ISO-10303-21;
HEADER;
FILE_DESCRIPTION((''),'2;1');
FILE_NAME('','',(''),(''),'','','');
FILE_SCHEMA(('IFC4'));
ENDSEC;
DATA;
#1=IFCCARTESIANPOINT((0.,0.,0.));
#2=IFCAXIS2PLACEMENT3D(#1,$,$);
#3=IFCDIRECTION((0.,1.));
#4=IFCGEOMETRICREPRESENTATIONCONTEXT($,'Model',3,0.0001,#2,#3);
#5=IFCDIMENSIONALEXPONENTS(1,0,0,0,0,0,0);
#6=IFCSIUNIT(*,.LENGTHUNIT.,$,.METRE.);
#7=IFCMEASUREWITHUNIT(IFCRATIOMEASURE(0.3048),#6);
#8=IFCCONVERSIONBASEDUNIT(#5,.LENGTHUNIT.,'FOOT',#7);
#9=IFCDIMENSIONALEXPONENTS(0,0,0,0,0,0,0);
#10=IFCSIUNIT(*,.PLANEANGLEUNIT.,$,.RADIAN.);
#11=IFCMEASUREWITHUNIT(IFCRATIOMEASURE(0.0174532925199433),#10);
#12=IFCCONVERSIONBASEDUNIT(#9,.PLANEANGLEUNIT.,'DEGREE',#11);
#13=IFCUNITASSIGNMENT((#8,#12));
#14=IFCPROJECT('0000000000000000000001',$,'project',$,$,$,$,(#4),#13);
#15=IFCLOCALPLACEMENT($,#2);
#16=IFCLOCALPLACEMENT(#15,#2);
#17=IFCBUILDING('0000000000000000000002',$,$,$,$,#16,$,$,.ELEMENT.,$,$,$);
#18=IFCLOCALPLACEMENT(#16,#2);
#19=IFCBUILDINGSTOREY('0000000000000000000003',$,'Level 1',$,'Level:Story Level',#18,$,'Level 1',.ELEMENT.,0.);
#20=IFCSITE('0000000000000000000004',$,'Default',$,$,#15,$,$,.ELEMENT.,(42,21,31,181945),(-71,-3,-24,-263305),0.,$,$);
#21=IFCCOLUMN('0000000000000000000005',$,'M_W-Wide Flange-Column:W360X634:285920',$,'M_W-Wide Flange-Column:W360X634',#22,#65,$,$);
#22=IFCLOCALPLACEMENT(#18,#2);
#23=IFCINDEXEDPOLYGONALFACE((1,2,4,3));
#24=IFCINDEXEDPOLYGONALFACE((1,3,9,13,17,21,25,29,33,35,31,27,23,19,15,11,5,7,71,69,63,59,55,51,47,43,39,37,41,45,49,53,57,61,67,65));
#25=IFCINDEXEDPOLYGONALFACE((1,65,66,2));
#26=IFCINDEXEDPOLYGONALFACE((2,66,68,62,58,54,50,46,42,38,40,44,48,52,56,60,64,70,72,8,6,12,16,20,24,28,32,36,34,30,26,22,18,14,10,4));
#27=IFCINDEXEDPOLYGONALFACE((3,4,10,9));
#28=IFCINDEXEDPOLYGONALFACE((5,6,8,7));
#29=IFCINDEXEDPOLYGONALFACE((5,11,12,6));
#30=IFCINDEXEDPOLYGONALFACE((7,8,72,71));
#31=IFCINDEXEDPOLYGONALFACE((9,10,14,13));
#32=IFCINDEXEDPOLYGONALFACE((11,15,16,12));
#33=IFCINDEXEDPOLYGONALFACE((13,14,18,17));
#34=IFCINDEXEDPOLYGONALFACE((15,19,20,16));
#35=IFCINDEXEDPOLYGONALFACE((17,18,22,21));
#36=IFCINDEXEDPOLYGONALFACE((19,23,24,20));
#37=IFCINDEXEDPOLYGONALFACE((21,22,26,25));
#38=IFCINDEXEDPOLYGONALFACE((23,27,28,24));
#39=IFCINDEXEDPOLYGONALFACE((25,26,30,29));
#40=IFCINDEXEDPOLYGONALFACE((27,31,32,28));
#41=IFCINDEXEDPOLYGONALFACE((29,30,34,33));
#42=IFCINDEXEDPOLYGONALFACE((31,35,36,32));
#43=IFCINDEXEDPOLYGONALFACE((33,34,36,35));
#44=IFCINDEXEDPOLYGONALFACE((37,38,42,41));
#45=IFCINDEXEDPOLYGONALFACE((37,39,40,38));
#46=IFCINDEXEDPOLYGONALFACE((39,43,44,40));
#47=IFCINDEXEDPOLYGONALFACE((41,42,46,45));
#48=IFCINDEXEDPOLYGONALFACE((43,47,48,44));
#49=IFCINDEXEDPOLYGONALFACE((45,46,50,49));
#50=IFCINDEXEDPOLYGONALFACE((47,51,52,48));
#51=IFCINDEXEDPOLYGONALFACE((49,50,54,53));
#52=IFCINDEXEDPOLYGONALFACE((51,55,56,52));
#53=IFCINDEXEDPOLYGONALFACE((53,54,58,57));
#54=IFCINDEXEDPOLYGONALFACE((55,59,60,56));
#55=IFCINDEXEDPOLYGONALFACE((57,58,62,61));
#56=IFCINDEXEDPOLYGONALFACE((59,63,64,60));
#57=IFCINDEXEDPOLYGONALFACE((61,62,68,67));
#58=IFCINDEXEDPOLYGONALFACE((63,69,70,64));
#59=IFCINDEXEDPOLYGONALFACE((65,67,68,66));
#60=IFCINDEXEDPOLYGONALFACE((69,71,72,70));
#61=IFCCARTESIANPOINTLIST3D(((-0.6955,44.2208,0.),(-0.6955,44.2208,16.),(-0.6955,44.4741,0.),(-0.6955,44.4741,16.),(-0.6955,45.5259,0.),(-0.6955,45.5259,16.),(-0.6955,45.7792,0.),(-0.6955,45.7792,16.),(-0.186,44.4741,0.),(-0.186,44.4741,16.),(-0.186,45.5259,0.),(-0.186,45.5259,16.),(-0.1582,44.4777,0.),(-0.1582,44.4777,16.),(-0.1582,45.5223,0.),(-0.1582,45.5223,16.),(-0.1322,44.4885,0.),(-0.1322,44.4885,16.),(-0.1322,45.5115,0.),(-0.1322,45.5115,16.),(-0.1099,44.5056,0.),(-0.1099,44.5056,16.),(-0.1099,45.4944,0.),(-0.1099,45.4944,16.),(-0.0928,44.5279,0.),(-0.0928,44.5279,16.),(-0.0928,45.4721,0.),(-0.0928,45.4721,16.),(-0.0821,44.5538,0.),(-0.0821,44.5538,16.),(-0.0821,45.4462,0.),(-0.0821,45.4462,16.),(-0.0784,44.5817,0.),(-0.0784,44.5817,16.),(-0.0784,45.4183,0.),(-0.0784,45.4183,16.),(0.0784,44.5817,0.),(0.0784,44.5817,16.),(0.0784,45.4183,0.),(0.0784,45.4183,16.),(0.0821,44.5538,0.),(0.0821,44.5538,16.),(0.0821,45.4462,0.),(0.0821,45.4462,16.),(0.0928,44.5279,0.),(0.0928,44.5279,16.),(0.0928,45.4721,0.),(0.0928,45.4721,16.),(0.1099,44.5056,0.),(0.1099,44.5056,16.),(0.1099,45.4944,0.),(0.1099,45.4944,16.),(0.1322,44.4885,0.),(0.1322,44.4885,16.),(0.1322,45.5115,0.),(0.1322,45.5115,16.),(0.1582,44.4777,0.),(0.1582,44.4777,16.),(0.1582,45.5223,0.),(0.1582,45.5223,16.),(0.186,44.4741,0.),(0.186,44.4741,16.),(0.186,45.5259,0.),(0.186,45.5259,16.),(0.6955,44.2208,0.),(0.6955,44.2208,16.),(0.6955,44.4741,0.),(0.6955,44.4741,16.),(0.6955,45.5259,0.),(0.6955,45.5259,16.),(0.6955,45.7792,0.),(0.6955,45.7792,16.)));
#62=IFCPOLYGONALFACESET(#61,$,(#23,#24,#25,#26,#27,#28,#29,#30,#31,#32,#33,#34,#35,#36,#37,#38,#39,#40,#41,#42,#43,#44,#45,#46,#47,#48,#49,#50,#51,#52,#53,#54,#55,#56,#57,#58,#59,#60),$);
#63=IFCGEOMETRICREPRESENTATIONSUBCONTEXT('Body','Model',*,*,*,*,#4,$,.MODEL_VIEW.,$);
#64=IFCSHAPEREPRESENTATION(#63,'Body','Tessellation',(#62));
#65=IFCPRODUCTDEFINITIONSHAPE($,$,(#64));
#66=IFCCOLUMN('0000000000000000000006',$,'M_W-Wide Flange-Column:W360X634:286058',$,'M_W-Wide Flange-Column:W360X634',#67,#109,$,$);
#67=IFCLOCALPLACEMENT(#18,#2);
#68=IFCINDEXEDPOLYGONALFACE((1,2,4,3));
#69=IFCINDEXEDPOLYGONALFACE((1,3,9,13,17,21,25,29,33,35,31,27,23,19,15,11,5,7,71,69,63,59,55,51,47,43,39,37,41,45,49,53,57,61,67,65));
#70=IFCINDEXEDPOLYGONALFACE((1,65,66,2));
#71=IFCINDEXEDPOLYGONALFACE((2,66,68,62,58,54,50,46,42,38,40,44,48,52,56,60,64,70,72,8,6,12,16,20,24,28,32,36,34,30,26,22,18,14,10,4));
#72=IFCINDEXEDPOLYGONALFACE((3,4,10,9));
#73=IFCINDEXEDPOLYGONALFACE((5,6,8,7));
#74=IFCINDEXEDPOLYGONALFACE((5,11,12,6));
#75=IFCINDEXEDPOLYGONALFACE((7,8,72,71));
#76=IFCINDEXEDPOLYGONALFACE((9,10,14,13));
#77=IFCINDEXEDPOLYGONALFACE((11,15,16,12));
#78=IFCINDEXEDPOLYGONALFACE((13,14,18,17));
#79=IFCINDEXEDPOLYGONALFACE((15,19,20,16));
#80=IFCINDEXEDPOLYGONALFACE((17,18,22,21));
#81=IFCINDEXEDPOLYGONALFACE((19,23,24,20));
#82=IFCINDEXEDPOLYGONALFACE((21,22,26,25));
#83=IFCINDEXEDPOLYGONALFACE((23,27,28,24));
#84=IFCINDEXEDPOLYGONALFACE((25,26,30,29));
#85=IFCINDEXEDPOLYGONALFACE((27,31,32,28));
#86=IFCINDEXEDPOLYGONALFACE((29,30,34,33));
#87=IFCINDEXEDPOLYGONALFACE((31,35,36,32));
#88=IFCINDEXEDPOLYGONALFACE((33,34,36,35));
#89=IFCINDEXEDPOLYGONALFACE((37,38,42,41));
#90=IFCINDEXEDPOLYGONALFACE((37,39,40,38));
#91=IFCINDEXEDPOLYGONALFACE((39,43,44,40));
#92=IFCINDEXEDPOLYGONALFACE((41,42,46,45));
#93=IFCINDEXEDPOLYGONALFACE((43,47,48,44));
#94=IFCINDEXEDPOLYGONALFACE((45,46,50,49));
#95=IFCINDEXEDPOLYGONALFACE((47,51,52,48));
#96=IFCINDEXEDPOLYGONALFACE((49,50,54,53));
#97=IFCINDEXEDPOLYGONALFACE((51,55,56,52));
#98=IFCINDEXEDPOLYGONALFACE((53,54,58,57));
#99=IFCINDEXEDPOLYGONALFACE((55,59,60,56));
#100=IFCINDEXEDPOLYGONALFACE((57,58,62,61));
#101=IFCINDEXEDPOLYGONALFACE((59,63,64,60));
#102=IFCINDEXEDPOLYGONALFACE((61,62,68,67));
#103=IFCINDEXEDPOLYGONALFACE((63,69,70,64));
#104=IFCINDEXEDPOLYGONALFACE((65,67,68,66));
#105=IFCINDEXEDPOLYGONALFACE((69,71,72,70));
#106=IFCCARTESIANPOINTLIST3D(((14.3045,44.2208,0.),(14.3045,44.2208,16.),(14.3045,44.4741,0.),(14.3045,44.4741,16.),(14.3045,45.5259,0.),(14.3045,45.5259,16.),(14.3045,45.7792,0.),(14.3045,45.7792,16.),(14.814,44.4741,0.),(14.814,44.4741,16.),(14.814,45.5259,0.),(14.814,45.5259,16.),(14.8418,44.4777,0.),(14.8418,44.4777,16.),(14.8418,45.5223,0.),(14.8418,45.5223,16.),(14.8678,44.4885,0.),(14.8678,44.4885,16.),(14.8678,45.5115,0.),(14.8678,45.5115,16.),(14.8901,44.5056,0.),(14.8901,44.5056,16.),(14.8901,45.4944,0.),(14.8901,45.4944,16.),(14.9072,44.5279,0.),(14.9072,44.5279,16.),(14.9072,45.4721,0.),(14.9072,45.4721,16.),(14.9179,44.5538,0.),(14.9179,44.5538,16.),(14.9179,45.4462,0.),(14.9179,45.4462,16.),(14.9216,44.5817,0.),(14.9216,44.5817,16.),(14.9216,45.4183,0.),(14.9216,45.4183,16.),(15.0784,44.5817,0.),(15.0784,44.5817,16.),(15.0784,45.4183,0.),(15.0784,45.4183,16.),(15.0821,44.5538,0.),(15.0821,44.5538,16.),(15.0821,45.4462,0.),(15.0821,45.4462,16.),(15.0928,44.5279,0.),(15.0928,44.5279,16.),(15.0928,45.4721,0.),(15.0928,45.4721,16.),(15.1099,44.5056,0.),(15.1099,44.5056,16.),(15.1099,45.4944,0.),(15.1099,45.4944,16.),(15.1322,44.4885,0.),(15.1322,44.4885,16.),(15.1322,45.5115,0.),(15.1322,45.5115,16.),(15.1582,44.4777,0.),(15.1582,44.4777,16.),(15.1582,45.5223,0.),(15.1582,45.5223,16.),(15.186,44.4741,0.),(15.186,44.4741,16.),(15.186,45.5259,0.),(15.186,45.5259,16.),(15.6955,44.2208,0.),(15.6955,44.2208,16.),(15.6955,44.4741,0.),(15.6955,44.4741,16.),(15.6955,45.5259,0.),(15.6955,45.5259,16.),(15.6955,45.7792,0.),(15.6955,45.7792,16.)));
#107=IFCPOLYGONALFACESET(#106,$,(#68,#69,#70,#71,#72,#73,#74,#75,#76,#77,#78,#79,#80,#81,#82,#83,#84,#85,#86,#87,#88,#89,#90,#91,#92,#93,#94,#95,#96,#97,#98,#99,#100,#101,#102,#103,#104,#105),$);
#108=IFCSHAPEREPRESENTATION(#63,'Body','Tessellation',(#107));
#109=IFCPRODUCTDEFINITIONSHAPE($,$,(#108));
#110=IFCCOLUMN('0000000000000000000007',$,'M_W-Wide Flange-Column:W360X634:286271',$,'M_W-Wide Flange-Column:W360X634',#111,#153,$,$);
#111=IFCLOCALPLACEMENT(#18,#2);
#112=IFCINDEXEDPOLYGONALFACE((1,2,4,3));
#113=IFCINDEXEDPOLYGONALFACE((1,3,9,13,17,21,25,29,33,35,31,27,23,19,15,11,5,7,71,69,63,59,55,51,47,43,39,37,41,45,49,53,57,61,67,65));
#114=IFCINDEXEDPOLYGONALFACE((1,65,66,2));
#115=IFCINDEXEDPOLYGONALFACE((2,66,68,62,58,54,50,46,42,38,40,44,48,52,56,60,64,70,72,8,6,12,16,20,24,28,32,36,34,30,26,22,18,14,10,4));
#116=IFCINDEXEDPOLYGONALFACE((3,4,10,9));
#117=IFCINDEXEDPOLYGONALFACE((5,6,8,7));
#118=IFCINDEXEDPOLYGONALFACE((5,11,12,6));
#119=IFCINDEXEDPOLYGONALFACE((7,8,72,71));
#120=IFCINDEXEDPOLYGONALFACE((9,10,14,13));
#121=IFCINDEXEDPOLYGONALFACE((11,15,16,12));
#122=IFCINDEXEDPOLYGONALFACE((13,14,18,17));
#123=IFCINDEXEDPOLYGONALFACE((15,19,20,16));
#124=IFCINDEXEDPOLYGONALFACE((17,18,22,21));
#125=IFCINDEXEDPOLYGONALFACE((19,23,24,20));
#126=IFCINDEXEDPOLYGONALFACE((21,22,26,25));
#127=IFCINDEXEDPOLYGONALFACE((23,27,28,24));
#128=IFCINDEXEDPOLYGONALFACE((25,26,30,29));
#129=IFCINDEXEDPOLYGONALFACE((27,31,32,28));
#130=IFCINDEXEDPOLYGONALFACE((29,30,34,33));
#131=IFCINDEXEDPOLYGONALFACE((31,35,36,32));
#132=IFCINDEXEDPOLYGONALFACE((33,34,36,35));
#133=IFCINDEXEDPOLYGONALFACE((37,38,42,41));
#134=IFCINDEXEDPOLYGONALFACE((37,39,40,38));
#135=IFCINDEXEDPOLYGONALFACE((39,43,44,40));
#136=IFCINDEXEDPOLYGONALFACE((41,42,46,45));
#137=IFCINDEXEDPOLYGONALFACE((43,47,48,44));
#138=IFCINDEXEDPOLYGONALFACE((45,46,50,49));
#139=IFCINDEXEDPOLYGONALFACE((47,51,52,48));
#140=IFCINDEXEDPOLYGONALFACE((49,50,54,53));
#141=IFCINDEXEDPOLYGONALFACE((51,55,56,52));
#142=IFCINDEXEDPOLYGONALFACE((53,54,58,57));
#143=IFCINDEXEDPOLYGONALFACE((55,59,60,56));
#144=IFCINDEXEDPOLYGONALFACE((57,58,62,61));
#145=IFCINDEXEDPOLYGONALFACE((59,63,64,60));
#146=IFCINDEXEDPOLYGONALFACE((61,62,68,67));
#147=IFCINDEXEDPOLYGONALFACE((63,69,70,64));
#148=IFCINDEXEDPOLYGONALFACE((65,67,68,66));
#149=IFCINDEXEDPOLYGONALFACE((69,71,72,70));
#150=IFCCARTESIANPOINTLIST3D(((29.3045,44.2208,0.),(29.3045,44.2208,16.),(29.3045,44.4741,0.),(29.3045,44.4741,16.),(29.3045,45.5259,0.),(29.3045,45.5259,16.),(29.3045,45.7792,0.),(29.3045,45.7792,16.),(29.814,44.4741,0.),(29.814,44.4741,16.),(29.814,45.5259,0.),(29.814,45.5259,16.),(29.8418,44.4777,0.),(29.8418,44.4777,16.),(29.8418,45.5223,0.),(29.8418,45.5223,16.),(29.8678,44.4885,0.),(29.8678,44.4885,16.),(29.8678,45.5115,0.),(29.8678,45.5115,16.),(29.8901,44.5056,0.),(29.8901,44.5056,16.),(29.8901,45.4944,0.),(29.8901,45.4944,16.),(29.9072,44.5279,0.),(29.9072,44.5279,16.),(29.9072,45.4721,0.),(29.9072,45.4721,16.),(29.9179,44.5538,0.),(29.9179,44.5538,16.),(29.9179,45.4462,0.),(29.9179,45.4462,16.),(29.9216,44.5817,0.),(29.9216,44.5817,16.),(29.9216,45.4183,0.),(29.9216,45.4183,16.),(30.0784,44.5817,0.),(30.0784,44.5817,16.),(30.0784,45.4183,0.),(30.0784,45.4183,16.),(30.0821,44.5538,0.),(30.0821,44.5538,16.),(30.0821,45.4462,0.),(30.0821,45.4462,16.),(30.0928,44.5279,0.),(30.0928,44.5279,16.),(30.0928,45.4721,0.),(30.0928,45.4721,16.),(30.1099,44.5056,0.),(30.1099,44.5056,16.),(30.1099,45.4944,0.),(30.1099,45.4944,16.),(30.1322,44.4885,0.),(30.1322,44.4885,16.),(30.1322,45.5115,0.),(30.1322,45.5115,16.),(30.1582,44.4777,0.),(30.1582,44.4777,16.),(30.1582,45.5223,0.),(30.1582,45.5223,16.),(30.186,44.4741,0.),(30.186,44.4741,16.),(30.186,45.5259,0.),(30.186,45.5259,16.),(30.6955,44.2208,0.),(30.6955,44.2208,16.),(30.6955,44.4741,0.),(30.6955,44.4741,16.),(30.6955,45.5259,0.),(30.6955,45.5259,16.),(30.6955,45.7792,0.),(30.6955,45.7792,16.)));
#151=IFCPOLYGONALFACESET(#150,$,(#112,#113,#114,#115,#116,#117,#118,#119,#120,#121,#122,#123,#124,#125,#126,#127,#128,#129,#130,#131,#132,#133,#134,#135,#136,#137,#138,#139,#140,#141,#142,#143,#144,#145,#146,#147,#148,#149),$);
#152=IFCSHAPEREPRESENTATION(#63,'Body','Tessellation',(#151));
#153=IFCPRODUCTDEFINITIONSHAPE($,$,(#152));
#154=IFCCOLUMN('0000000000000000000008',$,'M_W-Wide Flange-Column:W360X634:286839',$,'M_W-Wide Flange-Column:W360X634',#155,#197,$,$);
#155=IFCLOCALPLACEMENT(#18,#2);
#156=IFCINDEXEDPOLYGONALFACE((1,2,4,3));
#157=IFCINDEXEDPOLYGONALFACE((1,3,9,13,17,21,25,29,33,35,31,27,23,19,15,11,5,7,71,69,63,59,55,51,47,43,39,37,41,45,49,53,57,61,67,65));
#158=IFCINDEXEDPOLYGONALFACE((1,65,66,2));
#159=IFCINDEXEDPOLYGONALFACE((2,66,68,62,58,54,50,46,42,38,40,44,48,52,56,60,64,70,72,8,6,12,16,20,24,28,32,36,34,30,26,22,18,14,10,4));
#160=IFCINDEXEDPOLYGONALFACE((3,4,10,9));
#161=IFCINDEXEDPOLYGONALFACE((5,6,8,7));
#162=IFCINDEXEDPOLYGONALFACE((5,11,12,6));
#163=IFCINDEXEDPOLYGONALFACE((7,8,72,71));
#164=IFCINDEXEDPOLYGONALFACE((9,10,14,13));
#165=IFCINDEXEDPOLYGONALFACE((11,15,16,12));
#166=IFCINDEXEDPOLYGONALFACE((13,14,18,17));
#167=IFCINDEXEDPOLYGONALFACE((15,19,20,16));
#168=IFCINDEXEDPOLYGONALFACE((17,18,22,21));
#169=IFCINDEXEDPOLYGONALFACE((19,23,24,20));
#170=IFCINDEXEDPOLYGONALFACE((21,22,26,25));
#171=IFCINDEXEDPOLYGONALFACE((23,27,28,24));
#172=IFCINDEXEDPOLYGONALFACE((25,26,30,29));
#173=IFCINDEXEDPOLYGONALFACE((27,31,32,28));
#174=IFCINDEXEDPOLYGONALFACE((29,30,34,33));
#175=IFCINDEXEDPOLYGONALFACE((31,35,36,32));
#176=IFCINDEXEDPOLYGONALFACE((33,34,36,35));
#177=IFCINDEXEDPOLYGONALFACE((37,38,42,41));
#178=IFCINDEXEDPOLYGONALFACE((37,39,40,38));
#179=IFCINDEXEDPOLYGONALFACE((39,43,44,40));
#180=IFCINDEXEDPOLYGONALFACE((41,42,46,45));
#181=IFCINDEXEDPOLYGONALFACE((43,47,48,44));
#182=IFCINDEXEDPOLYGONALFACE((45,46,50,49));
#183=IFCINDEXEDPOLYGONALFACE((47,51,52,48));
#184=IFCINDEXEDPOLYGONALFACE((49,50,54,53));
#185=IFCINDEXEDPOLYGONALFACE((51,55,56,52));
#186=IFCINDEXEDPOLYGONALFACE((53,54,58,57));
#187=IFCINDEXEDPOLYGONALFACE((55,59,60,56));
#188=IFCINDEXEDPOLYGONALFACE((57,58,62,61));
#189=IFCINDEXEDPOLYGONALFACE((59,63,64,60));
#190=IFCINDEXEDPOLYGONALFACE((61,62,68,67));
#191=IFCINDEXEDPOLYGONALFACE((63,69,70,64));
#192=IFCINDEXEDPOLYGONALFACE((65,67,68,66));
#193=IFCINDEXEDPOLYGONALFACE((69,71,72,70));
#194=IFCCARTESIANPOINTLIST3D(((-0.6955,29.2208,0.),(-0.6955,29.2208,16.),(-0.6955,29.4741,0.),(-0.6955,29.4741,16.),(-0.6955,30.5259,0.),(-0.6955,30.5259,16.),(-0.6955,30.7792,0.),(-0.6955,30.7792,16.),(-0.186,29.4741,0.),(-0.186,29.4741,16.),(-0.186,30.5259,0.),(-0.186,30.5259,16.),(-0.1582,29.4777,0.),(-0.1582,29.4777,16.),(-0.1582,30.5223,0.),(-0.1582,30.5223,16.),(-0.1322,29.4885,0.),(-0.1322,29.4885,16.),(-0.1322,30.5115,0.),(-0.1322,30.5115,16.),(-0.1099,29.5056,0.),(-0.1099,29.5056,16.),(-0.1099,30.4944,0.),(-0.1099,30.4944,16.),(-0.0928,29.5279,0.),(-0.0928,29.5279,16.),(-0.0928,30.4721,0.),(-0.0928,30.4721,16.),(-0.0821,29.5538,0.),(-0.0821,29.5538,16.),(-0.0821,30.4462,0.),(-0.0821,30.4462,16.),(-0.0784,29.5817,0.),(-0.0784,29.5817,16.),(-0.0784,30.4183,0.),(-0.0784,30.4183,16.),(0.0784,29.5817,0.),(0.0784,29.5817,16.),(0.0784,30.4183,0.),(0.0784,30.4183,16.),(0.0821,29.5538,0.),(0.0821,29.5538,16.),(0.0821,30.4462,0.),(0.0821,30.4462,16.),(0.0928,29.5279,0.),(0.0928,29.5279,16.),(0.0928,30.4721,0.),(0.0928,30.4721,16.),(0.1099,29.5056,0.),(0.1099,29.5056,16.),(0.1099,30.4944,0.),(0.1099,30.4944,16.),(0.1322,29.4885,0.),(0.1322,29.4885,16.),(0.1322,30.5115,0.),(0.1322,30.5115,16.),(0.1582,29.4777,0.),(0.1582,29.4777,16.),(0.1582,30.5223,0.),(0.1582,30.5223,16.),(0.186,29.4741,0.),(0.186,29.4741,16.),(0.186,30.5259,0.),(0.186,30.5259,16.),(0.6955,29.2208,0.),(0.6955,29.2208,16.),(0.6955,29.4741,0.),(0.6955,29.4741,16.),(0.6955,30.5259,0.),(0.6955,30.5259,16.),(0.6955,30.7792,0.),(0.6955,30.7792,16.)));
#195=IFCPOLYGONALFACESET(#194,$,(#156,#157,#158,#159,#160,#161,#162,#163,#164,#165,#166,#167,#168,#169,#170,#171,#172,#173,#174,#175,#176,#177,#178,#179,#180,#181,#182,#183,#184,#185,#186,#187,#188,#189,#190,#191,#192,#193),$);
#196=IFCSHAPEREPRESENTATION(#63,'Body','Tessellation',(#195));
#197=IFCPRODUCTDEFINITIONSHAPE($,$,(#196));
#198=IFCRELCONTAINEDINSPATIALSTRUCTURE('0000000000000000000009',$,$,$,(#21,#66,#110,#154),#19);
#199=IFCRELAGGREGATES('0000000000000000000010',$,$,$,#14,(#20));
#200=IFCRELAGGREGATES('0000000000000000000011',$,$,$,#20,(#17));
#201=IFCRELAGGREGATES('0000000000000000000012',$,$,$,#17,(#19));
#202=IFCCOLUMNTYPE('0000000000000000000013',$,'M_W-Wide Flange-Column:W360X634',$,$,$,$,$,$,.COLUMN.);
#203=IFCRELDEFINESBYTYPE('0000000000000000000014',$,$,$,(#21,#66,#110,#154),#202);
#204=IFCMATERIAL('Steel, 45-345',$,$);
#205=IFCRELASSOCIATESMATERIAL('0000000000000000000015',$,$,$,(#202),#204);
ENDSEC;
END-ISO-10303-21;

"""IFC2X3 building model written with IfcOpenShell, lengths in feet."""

from ifc_helpers import new_model, entity, si_unit, converted_unit, direction, frame, frame_2d, origin, place, context, subcontext, project, spatial, polyline, circle_curve, parameter, trimmed, segment, composite_curve, outline, extrude, source, transform, mapped, material, type_object, type_shapes, element, save


model = new_model("IFC2X3")

# Units and contexts
model_context = context("Model", 3, precision=0.0001, world=origin(), true_north=direction((0.0, 1.0)))
body_context = subcontext(model_context, "Body", "Model", "MODEL_VIEW")
ifc_project = project(units=[converted_unit("LENGTHUNIT", "FOOT", entity("IfcRatioMeasure", 0.3048), si_unit("LENGTHUNIT", "METRE"), dimensions=[1, 0, 0, 0, 0, 0, 0]), converted_unit("PLANEANGLEUNIT", "DEGREE", entity("IfcRatioMeasure", 0.0174532925199433), si_unit("PLANEANGLEUNIT", "RADIAN"), dimensions=[0, 0, 0, 0, 0, 0, 0])], contexts=[model_context])

# Site, building, storey
site_placement = place(None, origin())
site = spatial("IfcSite", under=ifc_project, at=site_placement, Name="Default", CompositionType="ELEMENT", RefLatitude=(42, 21, 31, 181945), RefLongitude=(-71, -3, -24, -263305), RefElevation=0.0)
building_placement = place(site_placement, origin())
building = spatial("IfcBuilding", under=site, at=building_placement, CompositionType="ELEMENT")
storey_placement = place(building_placement, origin())
storey = spatial("IfcBuildingStorey", under=building, at=storey_placement, Name="Level 1", ObjectType="Level:Story Level", LongName="Level 1", CompositionType="ELEMENT", Elevation=0.0)

# Columns
ifc_material = material(Name="Steel, 45-345")
column_type = type_object("IfcColumnType", Name="M_W-Wide Flange-Column:W360X634", PredefinedType="COLUMN", material=ifc_material)
shared_shape = source(origin(), body_context, "Body", "SweptSolid", [
    extrude(outline(composite_curve([segment(polyline([(0.5259, -0.6955), (0.7792, -0.6955)]), True, "CONTINUOUS"), segment(polyline([(0.7792, -0.6955), (0.7792, 0.6955)]), True, "CONTINUOUS"), segment(polyline([(0.7792, 0.6955), (0.5259, 0.6955)]), True, "CONTINUOUS"), segment(polyline([(0.5259, 0.6955), (0.5259, 0.186)]), True, "CONTINUOUS"), segment(trimmed(circle_curve(frame_2d((0.4183, 0.186), x_axis=(1.0, 0.0)), 0.1076), [parameter(270.0)], [parameter(0.0)], True, "PARAMETER"), False, "CONTINUOUS"), segment(polyline([(0.4183, 0.0784), (-0.4183, 0.0784)]), True, "CONTINUOUS"), segment(trimmed(circle_curve(frame_2d((-0.4183, 0.186), x_axis=(0.0, -1.0)), 0.1076), [parameter(270.0)], [parameter(0.0)], True, "PARAMETER"), False, "CONTINUOUS"), segment(polyline([(-0.5259, 0.186), (-0.5259, 0.6955)]), True, "CONTINUOUS"), segment(polyline([(-0.5259, 0.6955), (-0.7792, 0.6955)]), True, "CONTINUOUS"), segment(polyline([(-0.7792, 0.6955), (-0.7792, -0.6955)]), True, "CONTINUOUS"), segment(polyline([(-0.7792, -0.6955), (-0.5259, -0.6955)]), True, "CONTINUOUS"), segment(polyline([(-0.5259, -0.6955), (-0.5259, -0.186)]), True, "CONTINUOUS"), segment(trimmed(circle_curve(frame_2d((-0.4183, -0.186), x_axis=(-1.0, 0.0)), 0.1076), [parameter(270.0)], [parameter(0.0)], True, "PARAMETER"), False, "CONTINUOUS"), segment(polyline([(-0.4183, -0.0784), (0.4183, -0.0784)]), True, "CONTINUOUS"), segment(trimmed(circle_curve(frame_2d((0.4183, -0.186), x_axis=(0.0, 1.0)), 0.1076), [parameter(270.0)], [parameter(0.0)], True, "PARAMETER"), False, "CONTINUOUS"), segment(polyline([(0.5259, -0.186), (0.5259, -0.6955)]), True, "CONTINUOUS")], self_intersect=False)), frame((0.0, 0.0, 0.0), z_axis=(0.0, 0.0, 1.0), x_axis=(0.0, -1.0, 0.0)), (0.0, 0.0, 1.0), 16.0),
])
type_shapes(column_type, [shared_shape])
for number, where, name in (
    (1, (0.0, 45.0, 0.0), "M_W-Wide Flange-Column:W360X634:285920"),
    (2, (15.0, 45.0, 0.0), "M_W-Wide Flange-Column:W360X634:286058"),
    (3, (30.0, 45.0, 0.0), "M_W-Wide Flange-Column:W360X634:286271"),
    (4, (0.0, 30.0, 0.0), "M_W-Wide Flange-Column:W360X634:286839"),
):
    element("IfcColumn", number, at=place(storey_placement, frame(where)), inside=storey, type_object=column_type, Name=name, ObjectType="M_W-Wide Flange-Column:W360X634", context=body_context, shape_type="MappedRepresentation", body=[
        mapped(shared_shape, transform((0.0, 0.0, 0.0), scale=1.0)),
    ])

save(model, "model.ifc")
